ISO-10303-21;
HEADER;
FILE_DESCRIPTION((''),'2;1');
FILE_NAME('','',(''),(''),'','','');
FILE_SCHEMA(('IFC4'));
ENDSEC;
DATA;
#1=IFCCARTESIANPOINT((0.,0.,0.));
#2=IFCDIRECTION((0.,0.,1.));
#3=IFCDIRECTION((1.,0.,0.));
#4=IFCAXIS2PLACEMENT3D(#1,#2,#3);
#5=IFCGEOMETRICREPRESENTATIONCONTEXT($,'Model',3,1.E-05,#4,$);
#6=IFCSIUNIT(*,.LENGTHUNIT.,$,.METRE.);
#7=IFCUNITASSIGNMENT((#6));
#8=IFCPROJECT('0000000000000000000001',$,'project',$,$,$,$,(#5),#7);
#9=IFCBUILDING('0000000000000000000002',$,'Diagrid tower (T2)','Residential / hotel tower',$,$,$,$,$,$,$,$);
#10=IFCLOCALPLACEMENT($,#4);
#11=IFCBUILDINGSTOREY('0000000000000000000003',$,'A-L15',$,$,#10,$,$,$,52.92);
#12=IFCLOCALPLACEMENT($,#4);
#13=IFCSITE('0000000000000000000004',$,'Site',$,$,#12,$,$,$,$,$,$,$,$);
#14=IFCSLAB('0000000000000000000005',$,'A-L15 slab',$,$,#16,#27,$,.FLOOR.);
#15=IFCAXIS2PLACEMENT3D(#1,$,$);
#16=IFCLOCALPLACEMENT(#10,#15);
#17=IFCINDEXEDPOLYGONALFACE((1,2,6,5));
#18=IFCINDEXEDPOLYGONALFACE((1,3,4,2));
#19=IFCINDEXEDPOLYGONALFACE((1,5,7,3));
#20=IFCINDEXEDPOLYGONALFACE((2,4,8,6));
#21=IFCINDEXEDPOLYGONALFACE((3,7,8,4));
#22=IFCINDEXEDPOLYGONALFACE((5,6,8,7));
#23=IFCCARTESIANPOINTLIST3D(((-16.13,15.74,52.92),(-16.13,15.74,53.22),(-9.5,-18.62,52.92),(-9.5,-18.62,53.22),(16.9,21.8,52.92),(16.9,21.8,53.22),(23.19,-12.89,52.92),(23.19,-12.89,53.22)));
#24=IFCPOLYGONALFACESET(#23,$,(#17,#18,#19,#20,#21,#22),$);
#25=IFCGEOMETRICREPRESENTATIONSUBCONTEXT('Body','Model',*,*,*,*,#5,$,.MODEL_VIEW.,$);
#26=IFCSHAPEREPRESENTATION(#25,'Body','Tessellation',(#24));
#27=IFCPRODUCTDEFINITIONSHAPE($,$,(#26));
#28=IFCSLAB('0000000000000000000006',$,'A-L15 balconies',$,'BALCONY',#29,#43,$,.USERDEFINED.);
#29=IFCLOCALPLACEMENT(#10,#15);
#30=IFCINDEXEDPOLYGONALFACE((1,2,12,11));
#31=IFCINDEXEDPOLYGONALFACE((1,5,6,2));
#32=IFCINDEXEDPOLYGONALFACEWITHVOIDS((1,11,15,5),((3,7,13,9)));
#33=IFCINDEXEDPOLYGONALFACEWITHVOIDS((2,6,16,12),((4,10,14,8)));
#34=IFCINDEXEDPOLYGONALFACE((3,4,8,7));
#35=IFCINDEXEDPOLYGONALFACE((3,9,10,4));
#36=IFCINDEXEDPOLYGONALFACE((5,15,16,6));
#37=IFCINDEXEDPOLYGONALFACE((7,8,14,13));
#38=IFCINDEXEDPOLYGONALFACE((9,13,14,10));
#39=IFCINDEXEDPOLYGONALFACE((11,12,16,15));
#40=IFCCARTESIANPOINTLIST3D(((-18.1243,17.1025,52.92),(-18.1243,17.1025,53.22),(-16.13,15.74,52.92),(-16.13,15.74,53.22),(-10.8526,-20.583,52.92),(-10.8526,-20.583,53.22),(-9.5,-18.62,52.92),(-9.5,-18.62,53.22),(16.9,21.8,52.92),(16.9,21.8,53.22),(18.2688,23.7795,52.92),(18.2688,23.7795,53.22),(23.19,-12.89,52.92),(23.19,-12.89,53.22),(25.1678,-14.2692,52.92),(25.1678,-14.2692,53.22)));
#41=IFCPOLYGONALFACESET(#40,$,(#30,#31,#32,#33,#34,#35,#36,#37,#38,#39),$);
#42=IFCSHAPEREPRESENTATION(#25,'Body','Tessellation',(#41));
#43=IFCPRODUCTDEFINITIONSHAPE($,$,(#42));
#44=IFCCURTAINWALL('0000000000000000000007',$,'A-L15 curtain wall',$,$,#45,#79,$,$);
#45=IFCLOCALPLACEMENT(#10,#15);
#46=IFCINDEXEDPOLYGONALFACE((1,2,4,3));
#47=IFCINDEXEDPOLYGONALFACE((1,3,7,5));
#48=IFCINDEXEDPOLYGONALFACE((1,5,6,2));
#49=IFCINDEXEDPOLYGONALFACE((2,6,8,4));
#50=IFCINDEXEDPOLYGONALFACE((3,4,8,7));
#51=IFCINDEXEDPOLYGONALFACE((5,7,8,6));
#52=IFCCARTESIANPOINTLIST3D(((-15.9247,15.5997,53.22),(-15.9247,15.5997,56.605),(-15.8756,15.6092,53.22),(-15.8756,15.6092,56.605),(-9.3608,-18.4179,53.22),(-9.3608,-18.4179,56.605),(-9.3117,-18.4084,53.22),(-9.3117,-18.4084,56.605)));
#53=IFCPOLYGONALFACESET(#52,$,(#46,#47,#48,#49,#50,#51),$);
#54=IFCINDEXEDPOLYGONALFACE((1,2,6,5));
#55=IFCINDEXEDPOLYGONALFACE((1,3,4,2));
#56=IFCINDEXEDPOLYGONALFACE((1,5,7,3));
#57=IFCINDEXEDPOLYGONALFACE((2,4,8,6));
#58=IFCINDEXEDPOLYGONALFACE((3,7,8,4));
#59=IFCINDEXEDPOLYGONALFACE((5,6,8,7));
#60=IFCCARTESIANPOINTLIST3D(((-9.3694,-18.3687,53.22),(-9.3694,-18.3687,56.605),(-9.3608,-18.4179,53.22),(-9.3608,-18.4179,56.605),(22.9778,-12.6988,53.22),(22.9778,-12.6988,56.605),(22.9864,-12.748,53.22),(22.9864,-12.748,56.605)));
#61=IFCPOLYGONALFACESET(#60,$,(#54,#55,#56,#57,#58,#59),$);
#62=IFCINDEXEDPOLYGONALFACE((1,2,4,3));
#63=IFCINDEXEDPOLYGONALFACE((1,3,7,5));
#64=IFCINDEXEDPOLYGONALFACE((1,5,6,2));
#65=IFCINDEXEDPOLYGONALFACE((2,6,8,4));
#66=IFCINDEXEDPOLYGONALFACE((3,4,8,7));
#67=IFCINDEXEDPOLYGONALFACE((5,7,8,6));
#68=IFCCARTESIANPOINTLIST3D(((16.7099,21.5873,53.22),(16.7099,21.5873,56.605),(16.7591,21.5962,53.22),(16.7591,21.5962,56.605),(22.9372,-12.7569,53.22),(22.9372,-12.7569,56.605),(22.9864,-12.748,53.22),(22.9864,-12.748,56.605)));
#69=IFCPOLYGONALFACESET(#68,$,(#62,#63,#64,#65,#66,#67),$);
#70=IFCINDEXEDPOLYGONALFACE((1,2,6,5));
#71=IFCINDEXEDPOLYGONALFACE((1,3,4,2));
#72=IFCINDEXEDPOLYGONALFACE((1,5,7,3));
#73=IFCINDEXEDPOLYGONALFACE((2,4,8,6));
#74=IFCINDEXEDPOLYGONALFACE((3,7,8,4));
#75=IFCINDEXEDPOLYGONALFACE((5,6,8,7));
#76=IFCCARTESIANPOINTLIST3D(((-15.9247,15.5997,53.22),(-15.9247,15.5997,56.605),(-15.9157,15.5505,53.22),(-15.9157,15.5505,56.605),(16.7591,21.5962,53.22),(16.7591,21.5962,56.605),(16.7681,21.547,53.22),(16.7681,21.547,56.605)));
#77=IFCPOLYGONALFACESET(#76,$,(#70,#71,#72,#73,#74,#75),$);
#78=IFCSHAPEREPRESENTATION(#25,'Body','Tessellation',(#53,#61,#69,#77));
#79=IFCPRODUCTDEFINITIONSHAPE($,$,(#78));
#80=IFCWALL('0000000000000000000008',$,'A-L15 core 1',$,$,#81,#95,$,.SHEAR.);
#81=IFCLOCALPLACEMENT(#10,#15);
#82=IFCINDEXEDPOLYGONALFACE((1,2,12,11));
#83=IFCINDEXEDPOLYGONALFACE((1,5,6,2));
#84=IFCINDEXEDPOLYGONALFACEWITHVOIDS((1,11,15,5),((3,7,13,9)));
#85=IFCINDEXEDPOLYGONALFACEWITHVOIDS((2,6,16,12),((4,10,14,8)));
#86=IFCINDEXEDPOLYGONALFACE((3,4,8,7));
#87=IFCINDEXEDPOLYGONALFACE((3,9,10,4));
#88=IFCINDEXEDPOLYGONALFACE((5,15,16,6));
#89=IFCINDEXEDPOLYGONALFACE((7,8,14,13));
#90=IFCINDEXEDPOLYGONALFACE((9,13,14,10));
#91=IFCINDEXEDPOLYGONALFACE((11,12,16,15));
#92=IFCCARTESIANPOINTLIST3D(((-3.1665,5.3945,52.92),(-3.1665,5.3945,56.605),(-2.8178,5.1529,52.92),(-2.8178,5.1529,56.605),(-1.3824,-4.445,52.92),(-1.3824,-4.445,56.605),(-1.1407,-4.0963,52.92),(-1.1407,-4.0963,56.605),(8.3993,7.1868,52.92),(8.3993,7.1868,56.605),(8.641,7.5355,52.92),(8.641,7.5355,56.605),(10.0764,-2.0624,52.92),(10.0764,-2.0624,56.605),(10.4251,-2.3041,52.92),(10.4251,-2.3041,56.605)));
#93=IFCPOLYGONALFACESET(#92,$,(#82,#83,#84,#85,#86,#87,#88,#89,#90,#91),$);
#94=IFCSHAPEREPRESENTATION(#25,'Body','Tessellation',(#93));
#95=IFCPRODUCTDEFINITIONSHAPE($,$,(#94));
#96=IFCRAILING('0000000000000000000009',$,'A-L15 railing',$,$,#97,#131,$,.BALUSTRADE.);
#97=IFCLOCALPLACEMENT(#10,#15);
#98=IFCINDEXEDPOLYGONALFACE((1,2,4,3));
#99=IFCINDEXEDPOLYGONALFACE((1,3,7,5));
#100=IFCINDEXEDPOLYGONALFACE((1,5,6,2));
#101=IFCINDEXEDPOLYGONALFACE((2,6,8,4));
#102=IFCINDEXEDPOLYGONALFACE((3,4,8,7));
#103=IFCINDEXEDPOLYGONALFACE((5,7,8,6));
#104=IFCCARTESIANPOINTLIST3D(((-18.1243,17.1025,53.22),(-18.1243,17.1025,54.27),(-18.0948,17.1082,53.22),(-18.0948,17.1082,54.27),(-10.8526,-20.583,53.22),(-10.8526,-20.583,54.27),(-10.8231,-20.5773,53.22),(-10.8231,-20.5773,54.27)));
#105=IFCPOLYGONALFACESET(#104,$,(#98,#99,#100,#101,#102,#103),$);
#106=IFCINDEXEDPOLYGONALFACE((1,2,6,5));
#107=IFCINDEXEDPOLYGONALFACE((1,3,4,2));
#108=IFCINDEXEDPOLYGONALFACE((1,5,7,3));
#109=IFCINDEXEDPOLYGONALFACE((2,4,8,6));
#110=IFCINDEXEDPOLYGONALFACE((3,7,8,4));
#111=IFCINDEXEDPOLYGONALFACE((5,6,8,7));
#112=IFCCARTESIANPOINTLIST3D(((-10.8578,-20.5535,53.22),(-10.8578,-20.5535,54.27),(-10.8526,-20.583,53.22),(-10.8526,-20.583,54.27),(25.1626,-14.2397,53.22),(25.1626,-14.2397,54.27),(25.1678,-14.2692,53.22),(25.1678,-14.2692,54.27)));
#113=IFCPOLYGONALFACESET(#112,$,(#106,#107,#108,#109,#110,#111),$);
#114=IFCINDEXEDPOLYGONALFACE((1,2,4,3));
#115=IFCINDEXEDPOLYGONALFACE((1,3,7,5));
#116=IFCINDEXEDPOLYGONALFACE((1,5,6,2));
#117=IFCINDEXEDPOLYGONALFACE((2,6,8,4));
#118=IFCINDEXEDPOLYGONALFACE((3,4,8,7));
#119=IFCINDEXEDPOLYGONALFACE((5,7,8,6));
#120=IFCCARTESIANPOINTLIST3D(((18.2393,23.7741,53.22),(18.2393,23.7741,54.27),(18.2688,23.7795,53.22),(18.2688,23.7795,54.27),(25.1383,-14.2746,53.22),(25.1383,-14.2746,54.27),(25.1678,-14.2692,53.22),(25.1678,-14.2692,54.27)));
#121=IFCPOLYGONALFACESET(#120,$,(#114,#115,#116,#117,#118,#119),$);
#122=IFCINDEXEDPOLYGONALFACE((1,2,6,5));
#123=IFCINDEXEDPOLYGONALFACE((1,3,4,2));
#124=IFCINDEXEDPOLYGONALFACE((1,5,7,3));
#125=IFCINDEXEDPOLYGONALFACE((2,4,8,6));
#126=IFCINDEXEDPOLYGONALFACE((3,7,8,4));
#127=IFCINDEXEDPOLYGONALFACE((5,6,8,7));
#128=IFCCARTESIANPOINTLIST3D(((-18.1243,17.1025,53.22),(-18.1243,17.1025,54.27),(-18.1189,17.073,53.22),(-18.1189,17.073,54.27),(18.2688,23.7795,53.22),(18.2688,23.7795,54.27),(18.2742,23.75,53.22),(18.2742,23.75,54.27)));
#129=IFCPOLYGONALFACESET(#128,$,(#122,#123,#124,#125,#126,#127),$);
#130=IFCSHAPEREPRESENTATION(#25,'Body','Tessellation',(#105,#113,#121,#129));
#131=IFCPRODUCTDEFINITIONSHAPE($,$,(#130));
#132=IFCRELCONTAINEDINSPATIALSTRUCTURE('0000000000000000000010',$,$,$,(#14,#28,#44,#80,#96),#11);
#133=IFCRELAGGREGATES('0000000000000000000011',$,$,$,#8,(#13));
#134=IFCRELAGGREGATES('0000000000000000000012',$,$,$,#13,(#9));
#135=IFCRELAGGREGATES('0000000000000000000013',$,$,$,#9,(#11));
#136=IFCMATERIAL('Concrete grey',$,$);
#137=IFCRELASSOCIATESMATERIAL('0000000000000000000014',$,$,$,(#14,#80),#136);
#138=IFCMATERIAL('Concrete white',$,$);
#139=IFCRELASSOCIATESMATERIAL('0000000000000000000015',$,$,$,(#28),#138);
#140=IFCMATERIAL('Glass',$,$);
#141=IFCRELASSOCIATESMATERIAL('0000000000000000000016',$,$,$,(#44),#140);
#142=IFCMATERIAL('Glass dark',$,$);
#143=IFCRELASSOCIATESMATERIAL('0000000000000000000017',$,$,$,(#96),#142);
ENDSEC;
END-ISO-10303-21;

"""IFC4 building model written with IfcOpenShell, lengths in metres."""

from ifc_helpers import new_model, si_unit, frame, origin_with_axes, place, context, subcontext, project, spatial, polyline, outline, extrude, material, element, save


model = new_model("IFC4")

# Units and contexts
model_context = context("Model", 3, precision=1e-05, world=origin_with_axes())
body_context = subcontext(model_context, "Body", "Model", "MODEL_VIEW")
ifc_project = project(units=[si_unit("LENGTHUNIT", "METRE")], contexts=[model_context])

# Site, building, storey
site_placement = place(None, origin_with_axes())
site = spatial("IfcSite", under=ifc_project, at=site_placement, Name="Site")
building = spatial("IfcBuilding", under=site, Name="Diagrid tower (T2)", Description="Residential / hotel tower")
storey_placement = place(None, origin_with_axes())
storey = spatial("IfcBuildingStorey", under=building, at=storey_placement, Name="A-L15", Elevation=52.92)

# Slabs
ifc_material_1 = material(Name="Concrete grey")
slab_1_placement = place(storey_placement, origin_with_axes())
element("IfcSlab", 1, at=slab_1_placement, inside=storey, material=ifc_material_1, Name="A-L15 slab", PredefinedType="FLOOR", context=body_context, shape_type="SweptSolid", body=[
    extrude(outline(polyline([(-16.13, 15.74), (-9.5, -18.62), (23.19, -12.89), (16.9, 21.8), (-16.13, 15.74)])), frame((0.0, 0.0, 52.92), z_axis=(0.0, 0.0, 1.0), x_axis=(1.0, 0.0, 0.0)), (0.0, 0.0, 1.0), 0.3),
])
ifc_material_2 = material(Name="Concrete white")
slab_2_placement = place(storey_placement, origin_with_axes())
element("IfcSlab", 2, at=slab_2_placement, inside=storey, material=ifc_material_2, Name="A-L15 balconies", ObjectType="BALCONY", PredefinedType="USERDEFINED", context=body_context, shape_type="SweptSolid", body=[
    extrude(outline(polyline([(-18.1243, 17.1025), (-10.8526, -20.583), (25.1678, -14.2692), (18.2688, 23.7795), (-18.1243, 17.1025)]), holes=[polyline([(-16.13, 15.74), (-9.5, -18.62), (23.19, -12.89), (16.9, 21.8), (-16.13, 15.74)])]), frame((0.0, 0.0, 52.92), z_axis=(0.0, 0.0, 1.0), x_axis=(1.0, 0.0, 0.0)), (0.0, 0.0, 1.0), 0.3),
])

# Curtain wall
ifc_material_3 = material(Name="Glass")
curtain_wall_placement = place(storey_placement, origin_with_axes())
element("IfcCurtainWall", 3, at=curtain_wall_placement, inside=storey, material=ifc_material_3, Name="A-L15 curtain wall", context=body_context, shape_type="SweptSolid", body=[
    extrude(outline(polyline([(-15.9247, 15.5997), (-9.3608, -18.4179), (-9.3117, -18.4084), (-15.8756, 15.6092), (-15.9247, 15.5997)])), frame((0.0, 0.0, 53.22), z_axis=(0.0, 0.0, 1.0), x_axis=(1.0, 0.0, 0.0)), (0.0, 0.0, 1.0), 3.385),
    extrude(outline(polyline([(-9.3608, -18.4179), (22.9864, -12.748), (22.9778, -12.6988), (-9.3694, -18.3687), (-9.3608, -18.4179)])), frame((0.0, 0.0, 53.22), z_axis=(0.0, 0.0, 1.0), x_axis=(1.0, 0.0, 0.0)), (0.0, 0.0, 1.0), 3.385),
    extrude(outline(polyline([(22.9864, -12.748), (16.7591, 21.5962), (16.7099, 21.5873), (22.9372, -12.7569), (22.9864, -12.748)])), frame((0.0, 0.0, 53.22), z_axis=(0.0, 0.0, 1.0), x_axis=(1.0, 0.0, 0.0)), (0.0, 0.0, 1.0), 3.385),
    extrude(outline(polyline([(16.7591, 21.5962), (-15.9247, 15.5997), (-15.9157, 15.5505), (16.7681, 21.547), (16.7591, 21.5962)])), frame((0.0, 0.0, 53.22), z_axis=(0.0, 0.0, 1.0), x_axis=(1.0, 0.0, 0.0)), (0.0, 0.0, 1.0), 3.385),
])

# Wall
wall_placement = place(storey_placement, origin_with_axes())
element("IfcWall", 4, at=wall_placement, inside=storey, material=ifc_material_1, Name="A-L15 core 1", PredefinedType="SHEAR", context=body_context, shape_type="SweptSolid", body=[
    extrude(outline(polyline([(10.4251, -2.3041), (8.641, 7.5355), (-3.1665, 5.3945), (-1.3824, -4.445), (10.4251, -2.3041)]), holes=[polyline([(10.0764, -2.0624), (8.3993, 7.1868), (-2.8178, 5.1529), (-1.1407, -4.0963), (10.0764, -2.0624)])]), frame((0.0, 0.0, 52.92), z_axis=(0.0, 0.0, 1.0), x_axis=(1.0, 0.0, 0.0)), (0.0, 0.0, 1.0), 3.685),
])

# Railing
ifc_material_4 = material(Name="Glass dark")
railing_placement = place(storey_placement, origin_with_axes())
element("IfcRailing", 5, at=railing_placement, inside=storey, material=ifc_material_4, Name="A-L15 railing", PredefinedType="BALUSTRADE", context=body_context, shape_type="SweptSolid", body=[
    extrude(outline(polyline([(-18.1243, 17.1025), (-10.8526, -20.583), (-10.8231, -20.5773), (-18.0948, 17.1082), (-18.1243, 17.1025)])), frame((0.0, 0.0, 53.22), z_axis=(0.0, 0.0, 1.0), x_axis=(1.0, 0.0, 0.0)), (0.0, 0.0, 1.0), 1.05),
    extrude(outline(polyline([(-10.8526, -20.583), (25.1678, -14.2692), (25.1626, -14.2397), (-10.8578, -20.5535), (-10.8526, -20.583)])), frame((0.0, 0.0, 53.22), z_axis=(0.0, 0.0, 1.0), x_axis=(1.0, 0.0, 0.0)), (0.0, 0.0, 1.0), 1.05),
    extrude(outline(polyline([(25.1678, -14.2692), (18.2688, 23.7795), (18.2393, 23.7741), (25.1383, -14.2746), (25.1678, -14.2692)])), frame((0.0, 0.0, 53.22), z_axis=(0.0, 0.0, 1.0), x_axis=(1.0, 0.0, 0.0)), (0.0, 0.0, 1.0), 1.05),
    extrude(outline(polyline([(18.2688, 23.7795), (-18.1243, 17.1025), (-18.1189, 17.073), (18.2742, 23.75), (18.2688, 23.7795)])), frame((0.0, 0.0, 53.22), z_axis=(0.0, 0.0, 1.0), x_axis=(1.0, 0.0, 0.0)), (0.0, 0.0, 1.0), 1.05),
])

save(model, "model.ifc")
